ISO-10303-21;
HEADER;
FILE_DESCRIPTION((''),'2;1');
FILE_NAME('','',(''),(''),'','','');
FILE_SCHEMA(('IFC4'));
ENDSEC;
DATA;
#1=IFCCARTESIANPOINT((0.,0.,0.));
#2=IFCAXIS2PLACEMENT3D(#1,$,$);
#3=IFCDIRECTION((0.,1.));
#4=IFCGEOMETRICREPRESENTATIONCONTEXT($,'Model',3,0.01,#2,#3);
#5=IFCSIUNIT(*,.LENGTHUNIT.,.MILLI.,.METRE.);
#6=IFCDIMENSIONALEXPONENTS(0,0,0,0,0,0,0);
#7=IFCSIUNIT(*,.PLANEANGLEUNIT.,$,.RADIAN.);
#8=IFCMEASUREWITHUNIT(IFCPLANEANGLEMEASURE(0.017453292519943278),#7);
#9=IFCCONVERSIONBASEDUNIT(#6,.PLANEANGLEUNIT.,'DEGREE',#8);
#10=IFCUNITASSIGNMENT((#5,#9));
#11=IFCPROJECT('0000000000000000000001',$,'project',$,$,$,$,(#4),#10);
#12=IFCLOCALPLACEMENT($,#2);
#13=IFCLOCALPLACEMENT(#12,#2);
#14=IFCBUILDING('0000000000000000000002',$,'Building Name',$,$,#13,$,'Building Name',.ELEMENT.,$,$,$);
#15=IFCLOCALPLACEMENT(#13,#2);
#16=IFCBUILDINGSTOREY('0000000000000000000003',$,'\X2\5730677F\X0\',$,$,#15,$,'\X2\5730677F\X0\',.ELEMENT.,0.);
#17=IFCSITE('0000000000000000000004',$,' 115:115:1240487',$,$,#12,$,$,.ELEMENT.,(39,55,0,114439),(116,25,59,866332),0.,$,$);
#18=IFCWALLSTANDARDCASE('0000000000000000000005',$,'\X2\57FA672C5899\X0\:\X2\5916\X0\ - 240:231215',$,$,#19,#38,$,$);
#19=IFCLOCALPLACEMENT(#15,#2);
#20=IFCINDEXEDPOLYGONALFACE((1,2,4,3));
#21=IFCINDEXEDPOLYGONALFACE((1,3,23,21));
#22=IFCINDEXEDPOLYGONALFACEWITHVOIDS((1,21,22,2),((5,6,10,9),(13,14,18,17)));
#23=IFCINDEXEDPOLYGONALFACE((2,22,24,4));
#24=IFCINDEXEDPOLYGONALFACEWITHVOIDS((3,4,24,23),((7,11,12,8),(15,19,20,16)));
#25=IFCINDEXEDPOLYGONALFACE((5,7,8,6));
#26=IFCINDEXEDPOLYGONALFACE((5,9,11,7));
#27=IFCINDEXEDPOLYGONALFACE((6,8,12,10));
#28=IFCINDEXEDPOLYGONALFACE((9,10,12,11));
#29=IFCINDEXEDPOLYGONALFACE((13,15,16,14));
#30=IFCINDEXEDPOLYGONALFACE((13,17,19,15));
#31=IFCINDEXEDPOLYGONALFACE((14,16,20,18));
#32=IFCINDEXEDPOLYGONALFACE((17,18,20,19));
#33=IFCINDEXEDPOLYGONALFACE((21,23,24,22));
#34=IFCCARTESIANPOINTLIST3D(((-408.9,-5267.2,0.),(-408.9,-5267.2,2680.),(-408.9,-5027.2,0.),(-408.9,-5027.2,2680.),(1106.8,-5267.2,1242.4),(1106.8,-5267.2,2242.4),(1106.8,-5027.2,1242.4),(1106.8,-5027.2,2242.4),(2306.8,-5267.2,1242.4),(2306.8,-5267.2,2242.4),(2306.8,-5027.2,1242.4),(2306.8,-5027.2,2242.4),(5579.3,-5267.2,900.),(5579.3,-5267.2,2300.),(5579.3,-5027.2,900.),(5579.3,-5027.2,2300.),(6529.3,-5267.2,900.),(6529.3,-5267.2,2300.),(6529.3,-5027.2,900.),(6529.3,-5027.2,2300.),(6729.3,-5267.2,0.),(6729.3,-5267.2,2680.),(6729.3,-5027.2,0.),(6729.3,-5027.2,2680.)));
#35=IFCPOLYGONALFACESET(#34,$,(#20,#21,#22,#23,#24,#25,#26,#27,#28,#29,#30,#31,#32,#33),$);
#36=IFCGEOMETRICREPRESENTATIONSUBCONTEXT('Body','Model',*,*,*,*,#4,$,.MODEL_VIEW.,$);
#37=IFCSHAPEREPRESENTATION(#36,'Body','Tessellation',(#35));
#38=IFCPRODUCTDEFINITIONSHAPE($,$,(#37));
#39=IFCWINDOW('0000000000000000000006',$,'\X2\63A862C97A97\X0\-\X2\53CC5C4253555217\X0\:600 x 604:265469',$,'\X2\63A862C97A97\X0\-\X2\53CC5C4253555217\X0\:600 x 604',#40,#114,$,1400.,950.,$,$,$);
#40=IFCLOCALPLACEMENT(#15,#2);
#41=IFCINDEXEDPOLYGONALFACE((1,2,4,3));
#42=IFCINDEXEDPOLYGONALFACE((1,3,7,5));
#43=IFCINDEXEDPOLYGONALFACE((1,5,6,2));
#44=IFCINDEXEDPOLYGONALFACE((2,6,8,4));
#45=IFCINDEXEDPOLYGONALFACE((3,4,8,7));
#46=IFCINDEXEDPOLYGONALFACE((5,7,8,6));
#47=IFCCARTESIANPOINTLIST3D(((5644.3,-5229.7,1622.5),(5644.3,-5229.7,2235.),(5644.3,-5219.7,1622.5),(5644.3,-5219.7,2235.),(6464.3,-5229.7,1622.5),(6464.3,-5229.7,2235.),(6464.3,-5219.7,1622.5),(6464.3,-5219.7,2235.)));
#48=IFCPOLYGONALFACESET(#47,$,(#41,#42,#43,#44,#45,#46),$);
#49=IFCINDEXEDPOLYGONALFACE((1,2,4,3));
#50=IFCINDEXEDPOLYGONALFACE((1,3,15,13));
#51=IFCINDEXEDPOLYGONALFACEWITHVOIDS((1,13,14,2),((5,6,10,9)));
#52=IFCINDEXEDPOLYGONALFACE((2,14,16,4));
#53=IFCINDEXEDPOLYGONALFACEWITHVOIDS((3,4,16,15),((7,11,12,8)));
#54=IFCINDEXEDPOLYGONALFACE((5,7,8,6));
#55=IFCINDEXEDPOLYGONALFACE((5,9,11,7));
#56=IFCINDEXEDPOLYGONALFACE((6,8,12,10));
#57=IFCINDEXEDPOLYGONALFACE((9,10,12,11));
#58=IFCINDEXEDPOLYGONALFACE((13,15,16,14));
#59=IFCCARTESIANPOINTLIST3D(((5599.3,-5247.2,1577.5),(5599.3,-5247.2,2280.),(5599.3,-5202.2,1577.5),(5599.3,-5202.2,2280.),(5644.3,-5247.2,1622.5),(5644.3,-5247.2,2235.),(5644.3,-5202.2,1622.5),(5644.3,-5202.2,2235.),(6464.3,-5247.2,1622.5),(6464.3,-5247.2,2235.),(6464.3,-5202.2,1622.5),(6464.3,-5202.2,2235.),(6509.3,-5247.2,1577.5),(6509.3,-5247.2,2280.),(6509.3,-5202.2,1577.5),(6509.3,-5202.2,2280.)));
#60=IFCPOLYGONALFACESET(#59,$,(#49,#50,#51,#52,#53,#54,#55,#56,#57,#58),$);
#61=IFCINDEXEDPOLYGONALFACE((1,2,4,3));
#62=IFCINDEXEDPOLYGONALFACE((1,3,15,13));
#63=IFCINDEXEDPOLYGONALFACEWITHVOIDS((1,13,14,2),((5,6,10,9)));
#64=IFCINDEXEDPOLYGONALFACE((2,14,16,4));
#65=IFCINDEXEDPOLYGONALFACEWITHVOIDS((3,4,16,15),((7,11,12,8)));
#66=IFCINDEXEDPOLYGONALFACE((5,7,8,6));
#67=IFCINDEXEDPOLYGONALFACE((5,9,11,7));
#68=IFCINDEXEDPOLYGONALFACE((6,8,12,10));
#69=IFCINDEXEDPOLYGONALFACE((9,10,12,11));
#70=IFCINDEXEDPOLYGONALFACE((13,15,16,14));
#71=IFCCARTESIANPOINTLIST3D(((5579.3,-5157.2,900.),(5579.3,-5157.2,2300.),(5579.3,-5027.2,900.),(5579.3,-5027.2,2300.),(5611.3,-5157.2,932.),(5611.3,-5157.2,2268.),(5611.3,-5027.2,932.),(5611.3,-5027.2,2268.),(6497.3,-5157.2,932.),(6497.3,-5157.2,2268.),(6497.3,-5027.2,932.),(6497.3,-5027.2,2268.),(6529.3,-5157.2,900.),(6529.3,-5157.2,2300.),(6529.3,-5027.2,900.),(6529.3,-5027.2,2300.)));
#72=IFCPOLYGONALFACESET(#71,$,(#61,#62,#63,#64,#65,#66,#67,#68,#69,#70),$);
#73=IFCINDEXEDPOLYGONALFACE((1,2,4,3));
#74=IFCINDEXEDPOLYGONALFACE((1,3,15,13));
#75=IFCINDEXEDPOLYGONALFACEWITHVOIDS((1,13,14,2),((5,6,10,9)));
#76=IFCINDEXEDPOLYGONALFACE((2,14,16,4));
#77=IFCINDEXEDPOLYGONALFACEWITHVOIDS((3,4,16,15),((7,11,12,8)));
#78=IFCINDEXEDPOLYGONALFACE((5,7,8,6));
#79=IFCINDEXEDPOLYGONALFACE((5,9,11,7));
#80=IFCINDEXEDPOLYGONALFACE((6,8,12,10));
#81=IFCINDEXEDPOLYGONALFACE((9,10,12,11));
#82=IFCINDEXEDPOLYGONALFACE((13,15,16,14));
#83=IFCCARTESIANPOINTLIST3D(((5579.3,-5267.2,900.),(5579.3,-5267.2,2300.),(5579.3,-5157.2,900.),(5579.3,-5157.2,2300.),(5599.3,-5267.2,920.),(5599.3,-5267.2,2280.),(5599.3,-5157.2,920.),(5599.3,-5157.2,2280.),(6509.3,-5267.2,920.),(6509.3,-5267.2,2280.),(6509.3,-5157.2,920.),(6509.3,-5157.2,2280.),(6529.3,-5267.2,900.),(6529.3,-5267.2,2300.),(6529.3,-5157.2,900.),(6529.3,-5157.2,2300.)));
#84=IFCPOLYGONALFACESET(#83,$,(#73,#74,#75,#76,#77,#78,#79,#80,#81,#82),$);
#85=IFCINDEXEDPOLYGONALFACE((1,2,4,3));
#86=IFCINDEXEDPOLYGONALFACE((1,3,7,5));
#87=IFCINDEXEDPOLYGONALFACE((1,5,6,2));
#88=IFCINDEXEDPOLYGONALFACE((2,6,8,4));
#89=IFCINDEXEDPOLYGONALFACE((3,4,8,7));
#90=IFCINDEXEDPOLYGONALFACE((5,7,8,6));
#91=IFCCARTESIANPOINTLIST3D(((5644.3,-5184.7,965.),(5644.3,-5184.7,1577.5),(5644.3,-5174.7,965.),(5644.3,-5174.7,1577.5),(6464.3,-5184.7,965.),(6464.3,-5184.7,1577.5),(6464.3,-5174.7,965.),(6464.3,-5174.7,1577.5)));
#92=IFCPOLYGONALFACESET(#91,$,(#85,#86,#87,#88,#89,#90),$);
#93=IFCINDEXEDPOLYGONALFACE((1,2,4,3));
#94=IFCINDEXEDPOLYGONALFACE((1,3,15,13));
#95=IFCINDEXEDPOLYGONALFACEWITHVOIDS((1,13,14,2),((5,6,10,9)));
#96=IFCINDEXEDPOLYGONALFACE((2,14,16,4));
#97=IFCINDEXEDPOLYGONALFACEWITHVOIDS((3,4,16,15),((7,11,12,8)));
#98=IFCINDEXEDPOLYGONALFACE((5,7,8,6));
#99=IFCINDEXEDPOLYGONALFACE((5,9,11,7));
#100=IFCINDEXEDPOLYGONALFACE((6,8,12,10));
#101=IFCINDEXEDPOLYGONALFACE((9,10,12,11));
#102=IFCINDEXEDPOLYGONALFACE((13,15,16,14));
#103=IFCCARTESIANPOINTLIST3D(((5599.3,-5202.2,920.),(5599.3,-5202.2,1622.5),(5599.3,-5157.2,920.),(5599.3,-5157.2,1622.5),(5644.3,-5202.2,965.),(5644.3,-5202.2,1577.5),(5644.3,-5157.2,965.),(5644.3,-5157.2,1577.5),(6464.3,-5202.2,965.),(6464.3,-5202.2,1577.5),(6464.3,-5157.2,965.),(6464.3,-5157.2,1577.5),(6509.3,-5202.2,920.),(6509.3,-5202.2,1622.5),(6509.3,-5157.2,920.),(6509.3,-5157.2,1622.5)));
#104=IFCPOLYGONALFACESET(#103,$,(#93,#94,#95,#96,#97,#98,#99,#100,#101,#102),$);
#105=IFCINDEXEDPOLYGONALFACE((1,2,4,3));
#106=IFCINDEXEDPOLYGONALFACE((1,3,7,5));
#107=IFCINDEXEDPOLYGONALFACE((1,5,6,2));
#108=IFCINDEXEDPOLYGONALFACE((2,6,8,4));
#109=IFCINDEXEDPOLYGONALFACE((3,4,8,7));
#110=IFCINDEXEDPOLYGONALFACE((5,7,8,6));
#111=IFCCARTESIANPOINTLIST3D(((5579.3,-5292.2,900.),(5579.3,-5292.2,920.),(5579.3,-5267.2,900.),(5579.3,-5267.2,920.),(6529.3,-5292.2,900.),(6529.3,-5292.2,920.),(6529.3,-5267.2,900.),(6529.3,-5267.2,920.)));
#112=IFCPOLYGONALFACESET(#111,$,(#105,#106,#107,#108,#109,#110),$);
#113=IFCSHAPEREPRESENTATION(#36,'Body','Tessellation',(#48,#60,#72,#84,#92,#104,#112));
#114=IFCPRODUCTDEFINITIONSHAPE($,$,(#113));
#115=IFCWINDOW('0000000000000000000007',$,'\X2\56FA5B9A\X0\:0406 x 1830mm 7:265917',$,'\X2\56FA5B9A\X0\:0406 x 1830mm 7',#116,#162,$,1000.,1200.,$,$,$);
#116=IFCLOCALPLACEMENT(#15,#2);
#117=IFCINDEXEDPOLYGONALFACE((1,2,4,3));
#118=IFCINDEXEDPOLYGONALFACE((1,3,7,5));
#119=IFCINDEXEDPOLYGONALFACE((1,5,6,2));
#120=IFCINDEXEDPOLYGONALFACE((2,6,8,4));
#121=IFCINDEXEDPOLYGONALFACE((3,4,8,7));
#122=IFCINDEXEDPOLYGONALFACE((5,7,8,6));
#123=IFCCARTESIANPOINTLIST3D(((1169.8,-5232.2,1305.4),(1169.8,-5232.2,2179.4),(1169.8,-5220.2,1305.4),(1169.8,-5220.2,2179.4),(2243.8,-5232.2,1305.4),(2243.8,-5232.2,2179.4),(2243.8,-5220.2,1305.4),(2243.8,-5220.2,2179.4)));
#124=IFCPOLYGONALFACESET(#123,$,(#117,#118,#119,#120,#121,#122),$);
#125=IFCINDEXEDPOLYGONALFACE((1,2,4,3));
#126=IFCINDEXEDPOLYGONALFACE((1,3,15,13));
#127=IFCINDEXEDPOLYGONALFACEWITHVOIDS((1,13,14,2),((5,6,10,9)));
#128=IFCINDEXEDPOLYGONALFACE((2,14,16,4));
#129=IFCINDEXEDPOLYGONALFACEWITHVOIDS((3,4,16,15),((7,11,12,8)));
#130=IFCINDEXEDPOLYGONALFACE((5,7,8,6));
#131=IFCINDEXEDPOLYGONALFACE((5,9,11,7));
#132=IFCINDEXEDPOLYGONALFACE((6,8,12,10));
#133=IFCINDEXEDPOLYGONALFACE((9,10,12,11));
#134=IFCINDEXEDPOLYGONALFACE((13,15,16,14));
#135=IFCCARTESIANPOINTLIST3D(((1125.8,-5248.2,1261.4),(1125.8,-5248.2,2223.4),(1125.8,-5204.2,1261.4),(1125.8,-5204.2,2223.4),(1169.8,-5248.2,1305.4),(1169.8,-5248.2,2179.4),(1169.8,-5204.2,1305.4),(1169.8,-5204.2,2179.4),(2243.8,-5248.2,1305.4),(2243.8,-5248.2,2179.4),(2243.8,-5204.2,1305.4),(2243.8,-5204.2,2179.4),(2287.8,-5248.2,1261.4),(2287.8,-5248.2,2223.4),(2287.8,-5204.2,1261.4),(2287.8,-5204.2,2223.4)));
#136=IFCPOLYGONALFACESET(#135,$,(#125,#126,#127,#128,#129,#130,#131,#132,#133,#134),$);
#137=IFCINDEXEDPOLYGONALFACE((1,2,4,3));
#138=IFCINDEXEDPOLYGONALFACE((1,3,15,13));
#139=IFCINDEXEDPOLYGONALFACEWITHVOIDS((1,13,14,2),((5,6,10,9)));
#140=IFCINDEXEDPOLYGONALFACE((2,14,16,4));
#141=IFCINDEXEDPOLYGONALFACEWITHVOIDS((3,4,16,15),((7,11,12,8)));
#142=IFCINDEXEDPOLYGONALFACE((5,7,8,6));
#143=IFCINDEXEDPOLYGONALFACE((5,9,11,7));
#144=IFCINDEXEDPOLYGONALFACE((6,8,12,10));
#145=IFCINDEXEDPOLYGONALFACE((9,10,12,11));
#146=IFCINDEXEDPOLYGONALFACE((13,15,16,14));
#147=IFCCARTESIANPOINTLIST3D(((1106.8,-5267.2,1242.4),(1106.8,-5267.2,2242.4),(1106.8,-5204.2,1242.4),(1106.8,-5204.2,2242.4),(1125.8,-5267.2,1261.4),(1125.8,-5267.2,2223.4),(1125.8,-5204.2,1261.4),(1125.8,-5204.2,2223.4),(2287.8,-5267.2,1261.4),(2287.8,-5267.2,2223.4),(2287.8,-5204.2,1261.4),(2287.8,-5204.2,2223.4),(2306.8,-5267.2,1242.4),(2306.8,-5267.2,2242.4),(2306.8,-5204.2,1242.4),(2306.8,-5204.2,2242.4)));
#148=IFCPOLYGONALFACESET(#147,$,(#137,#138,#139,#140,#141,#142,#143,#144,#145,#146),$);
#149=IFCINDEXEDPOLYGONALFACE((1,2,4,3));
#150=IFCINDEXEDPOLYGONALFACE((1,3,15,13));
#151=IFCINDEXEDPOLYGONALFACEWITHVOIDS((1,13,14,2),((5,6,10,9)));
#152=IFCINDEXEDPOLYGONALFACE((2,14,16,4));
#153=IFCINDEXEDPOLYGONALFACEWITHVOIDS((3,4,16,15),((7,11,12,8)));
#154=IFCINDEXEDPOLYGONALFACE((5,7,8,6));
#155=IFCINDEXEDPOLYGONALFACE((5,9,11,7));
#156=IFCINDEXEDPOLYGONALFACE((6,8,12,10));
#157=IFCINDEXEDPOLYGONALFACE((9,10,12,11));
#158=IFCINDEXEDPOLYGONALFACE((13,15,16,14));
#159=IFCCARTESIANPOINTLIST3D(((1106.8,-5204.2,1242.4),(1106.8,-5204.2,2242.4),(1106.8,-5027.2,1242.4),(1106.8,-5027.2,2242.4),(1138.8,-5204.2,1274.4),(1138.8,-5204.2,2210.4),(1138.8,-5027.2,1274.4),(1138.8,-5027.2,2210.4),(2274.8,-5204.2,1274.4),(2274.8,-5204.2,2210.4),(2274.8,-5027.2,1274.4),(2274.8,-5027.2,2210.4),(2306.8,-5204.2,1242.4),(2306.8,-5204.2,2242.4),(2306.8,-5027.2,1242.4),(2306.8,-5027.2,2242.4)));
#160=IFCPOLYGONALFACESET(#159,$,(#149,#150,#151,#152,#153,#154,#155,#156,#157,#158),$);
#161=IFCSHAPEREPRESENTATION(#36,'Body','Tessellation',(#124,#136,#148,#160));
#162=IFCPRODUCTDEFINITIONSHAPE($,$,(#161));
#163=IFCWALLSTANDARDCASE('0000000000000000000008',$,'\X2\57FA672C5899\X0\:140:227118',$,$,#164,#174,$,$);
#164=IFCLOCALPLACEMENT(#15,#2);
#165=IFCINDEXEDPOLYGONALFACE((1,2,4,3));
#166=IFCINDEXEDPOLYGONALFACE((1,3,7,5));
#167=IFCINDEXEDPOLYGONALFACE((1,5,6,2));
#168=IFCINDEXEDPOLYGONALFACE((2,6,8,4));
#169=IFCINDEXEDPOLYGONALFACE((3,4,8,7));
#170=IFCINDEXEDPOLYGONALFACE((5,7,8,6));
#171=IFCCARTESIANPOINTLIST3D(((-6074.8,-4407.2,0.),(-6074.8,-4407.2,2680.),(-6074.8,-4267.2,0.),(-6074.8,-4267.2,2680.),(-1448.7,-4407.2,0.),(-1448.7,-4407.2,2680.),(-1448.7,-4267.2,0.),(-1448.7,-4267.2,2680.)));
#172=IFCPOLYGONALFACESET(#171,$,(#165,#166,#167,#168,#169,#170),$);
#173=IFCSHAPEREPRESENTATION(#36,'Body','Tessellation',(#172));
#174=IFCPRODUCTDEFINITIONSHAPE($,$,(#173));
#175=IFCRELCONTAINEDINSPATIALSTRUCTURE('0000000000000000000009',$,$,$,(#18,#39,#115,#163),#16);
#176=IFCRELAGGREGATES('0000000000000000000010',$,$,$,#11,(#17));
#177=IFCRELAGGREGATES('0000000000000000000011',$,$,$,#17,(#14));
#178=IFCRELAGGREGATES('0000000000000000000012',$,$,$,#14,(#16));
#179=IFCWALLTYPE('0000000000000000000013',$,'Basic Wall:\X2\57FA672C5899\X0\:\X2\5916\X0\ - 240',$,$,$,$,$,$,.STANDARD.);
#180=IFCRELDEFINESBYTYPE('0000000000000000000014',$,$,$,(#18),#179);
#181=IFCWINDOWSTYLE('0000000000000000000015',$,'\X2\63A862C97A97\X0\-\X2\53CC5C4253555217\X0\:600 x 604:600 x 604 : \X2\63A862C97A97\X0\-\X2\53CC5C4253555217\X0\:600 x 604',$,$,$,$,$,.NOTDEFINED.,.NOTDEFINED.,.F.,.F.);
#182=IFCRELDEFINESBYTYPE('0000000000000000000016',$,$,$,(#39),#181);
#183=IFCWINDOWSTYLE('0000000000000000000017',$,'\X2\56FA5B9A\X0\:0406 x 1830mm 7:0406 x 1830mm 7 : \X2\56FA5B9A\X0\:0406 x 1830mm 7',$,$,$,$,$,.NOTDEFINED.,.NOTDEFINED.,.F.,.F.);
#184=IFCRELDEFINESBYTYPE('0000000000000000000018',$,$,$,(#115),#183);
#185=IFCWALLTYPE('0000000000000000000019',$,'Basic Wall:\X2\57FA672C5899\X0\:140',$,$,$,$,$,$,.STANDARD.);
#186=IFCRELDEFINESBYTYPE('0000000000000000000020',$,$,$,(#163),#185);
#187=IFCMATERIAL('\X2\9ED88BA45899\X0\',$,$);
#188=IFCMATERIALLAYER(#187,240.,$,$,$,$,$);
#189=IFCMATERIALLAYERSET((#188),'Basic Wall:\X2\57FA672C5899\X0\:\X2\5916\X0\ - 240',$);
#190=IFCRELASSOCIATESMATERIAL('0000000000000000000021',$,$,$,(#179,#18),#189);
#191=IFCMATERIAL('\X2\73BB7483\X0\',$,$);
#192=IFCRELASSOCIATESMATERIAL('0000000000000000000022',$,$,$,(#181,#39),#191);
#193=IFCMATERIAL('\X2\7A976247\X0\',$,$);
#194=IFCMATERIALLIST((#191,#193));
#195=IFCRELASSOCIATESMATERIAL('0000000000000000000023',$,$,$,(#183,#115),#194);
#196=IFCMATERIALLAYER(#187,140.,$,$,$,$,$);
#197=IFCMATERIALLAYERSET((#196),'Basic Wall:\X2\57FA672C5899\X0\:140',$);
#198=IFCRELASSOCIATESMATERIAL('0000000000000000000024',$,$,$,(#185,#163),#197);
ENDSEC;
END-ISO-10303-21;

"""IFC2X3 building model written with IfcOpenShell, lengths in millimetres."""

from ifc_helpers import new_model, entity, si_unit, converted_unit, direction, frame, frame_2d, origin, origin_2d_with_axis, place, context, subcontext, project, spatial, polyline, rectangle, outline, extrude, source, transform, mapped, material, material_list, layer, layer_set, layer_usage, type_object, type_shapes, element, fill, save


model = new_model("IFC2X3")

# Units and contexts
model_context = context("Model", 3, precision=0.01, world=origin(), true_north=direction((0.0, 1.0)))
body_context = subcontext(model_context, "Body", "Model", "MODEL_VIEW")
ifc_project = project(units=[si_unit("LENGTHUNIT", "METRE", prefix="MILLI"), converted_unit("PLANEANGLEUNIT", "DEGREE", entity("IfcPlaneAngleMeasure", 0.017453292519943278), si_unit("PLANEANGLEUNIT", "RADIAN"), dimensions=[0, 0, 0, 0, 0, 0, 0])], contexts=[model_context])

# Site, building, storey
site_placement = place(None, origin())
site = spatial("IfcSite", under=ifc_project, at=site_placement, Name=" 115:115:1240487", CompositionType="ELEMENT", RefLatitude=(39, 55, 0, 114439), RefLongitude=(116, 25, 59, 866332), RefElevation=0.0)
building_placement = place(site_placement, origin())
building = spatial("IfcBuilding", under=site, at=building_placement, Name="Building Name", LongName="Building Name", CompositionType="ELEMENT")
storey_placement = place(building_placement, origin())
storey = spatial("IfcBuildingStorey", under=building, at=storey_placement, Name="地板", LongName="地板", CompositionType="ELEMENT", Elevation=0.0)

# Shared definitions
ifc_material_1 = material(Name="默认墙")

# Shared definitions
ifc_layer_1 = layer(ifc_material_1, 240.0)
ifc_layer_set_1 = layer_set([ifc_layer_1], Name="Basic Wall:基本墙:外 - 240")
wall_type_1 = type_object("IfcWallType", Name="Basic Wall:基本墙:外 - 240", PredefinedType="STANDARD", material=ifc_layer_set_1)

# Wall, openings, windows
ifc_material_2 = material(Name="玻璃")
window_style_1 = type_object("IfcWindowStyle", Name="推拉窗-双层单列:600 x 604:600 x 604 : 推拉窗-双层单列:600 x 604", ConstructionType="NOTDEFINED", OperationType="NOTDEFINED", ParameterTakesPrecedence=False, Sizeable=False, material=ifc_material_2)
shared_shape_1 = source(origin(), body_context, "Body", "SweptSolid", [
    extrude(rectangle(XDim=820.0, YDim=10.0, at=origin_2d_with_axis()), frame((475.0, -44.9, 722.5)), (0.0, 0.0, 1.0), 612.5),
    extrude(outline(polyline([(-351.2, -455.0), (351.2, -455.0), (351.2, 455.0), (-351.2, 455.0), (-351.2, -455.0)]), holes=[polyline([(306.2, 410.0), (306.2, -410.0), (-306.2, -410.0), (-306.2, 410.0), (306.2, 410.0)])]), frame((475.0, -67.4, 1028.7), z_axis=(0.0, 1.0, 0.0), x_axis=(0.0, 0.0, -1.0)), (0.0, 0.0, 1.0), 45.0),
    extrude(outline(polyline([(-700.0, -475.0), (700.0, -475.0), (700.0, 475.0), (-700.0, 475.0), (-700.0, -475.0)]), holes=[polyline([(668.0, 443.0), (668.0, -443.0), (-668.0, -443.0), (-668.0, 443.0), (668.0, 443.0)])]), frame((475.0, -242.4, 700.0), z_axis=(0.0, 1.0, 0.0), x_axis=(0.0, 0.0, -1.0)), (0.0, 0.0, 1.0), 130.0),
    extrude(outline(polyline([(-475.0, -700.0), (475.0, -700.0), (475.0, 700.0), (-475.0, 700.0), (-475.0, -700.0)]), holes=[polyline([(455.0, 680.0), (455.0, -680.0), (-455.0, -680.0), (-455.0, 680.0), (455.0, 680.0)])]), frame((475.0, -112.4, 700.0), z_axis=(0.0, 1.0, 0.0), x_axis=(-1.0, 0.0, 0.0)), (0.0, 0.0, 1.0), 110.0),
    extrude(rectangle(XDim=820.0, YDim=10.0, at=origin_2d_with_axis()), frame((475.0, -89.9, 65.0)), (0.0, 0.0, 1.0), 612.5),
    extrude(outline(polyline([(-351.2, -455.0), (351.2, -455.0), (351.2, 455.0), (-351.2, 455.0), (-351.2, -455.0)]), holes=[polyline([(306.2, 410.0), (306.3, -410.0), (-306.2, -410.0), (-306.2, 410.0), (306.2, 410.0)])]), frame((475.0, -112.4, 371.3), z_axis=(0.0, 1.0, 0.0), x_axis=(0.0, 0.0, -1.0)), (0.0, 0.0, 1.0), 45.0),
    extrude(rectangle(XDim=950.0, YDim=25.0, at=origin_2d_with_axis()), frame((475.0, 10.1, 0.0)), (0.0, 0.0, 1.0), 20.0),
])
type_shapes(window_style_1, [shared_shape_1])
ifc_layer_usage_1 = layer_usage(ifc_layer_set_1, "AXIS2", "NEGATIVE", 120.0)
wall_1_placement = place(storey_placement, frame((-408.9, -5147.2, 0.0)))
wall_1 = element("IfcWallStandardCase", 1, at=wall_1_placement, inside=storey, type_object=wall_type_1, material=ifc_layer_usage_1, Name="基本墙:外 - 240:231215", context=body_context, shape_type="SweptSolid", body=[
    extrude(rectangle(XDim=7138.2, YDim=240.0, at=frame_2d((3569.1, 0.0), x_axis=(-1.0, 0.0))), origin(), (0.0, 0.0, 1.0), 2680.0),
])
opening_1_placement = place(wall_1_placement, frame((408.9, 5147.2, 0.0)))
opening_1 = element("IfcOpeningElement", 2, at=opening_1_placement, cuts=wall_1, ObjectType="Opening", context=body_context, shape_type="SweptSolid", body=[
    extrude(rectangle(XDim=1400.0, YDim=950.0, at=frame_2d((0.0, 0.0), x_axis=(1.0, 0.0))), frame((6054.3, -5269.6, 1600.0), z_axis=(0.0, 1.0, 0.0), x_axis=(0.0, 0.0, 1.0)), (0.0, 0.0, 1.0), 244.8),
])
opening_2_placement = place(wall_1_placement, frame((408.9, 5147.2, 0.0)))
opening_2 = element("IfcOpeningElement", 3, at=opening_2_placement, cuts=wall_1, ObjectType="Opening", context=body_context, shape_type="SweptSolid", body=[
    extrude(rectangle(XDim=1000.0, YDim=1200.0, at=origin_2d_with_axis()), frame((1706.8, -5269.6, 1742.4), z_axis=(0.0, 1.0, 0.0), x_axis=(0.0, 0.0, -1.0)), (0.0, 0.0, 1.0), 244.8),
])
window_1_placement = place(opening_1_placement, frame((6529.3, -5269.6, 900.0), z_axis=(0.0, 0.0, 1.0), x_axis=(-1.0, 0.0, 0.0)))
window_1 = element("IfcWindow", 4, at=window_1_placement, inside=storey, type_object=window_style_1, material=ifc_material_2, Name="推拉窗-双层单列:600 x 604:265469", ObjectType="推拉窗-双层单列:600 x 604", OverallHeight=1400.0, OverallWidth=950.0, context=body_context, shape_type="MappedRepresentation", body=[
    mapped(shared_shape_1, transform((0.0, 0.0, 0.0), scale=1.0)),
])
fill(opening_1, window_1)
ifc_material_3 = material(Name="窗扇")
ifc_material_list = material_list([ifc_material_2, ifc_material_3])
window_style_2 = type_object("IfcWindowStyle", Name="固定:0406 x 1830mm 7:0406 x 1830mm 7 : 固定:0406 x 1830mm 7", ConstructionType="NOTDEFINED", OperationType="NOTDEFINED", ParameterTakesPrecedence=False, Sizeable=False, material=ifc_material_list)
shared_shape_2 = source(origin(), body_context, "Body", "SweptSolid", [
    extrude(rectangle(XDim=1074.0, YDim=12.0, at=origin_2d_with_axis()), frame((600.0, 201.4, 63.0)), (0.0, 0.0, 1.0), 874.0),
    extrude(outline(polyline([(-481.0, -581.0), (481.0, -581.0), (481.0, 581.0), (-481.0, 581.0), (-481.0, -581.0)]), holes=[polyline([(437.0, 537.0), (437.0, -537.0), (-437.0, -537.0), (-437.0, 537.0), (437.0, 537.0)])]), frame((600.0, 179.4, 500.0), z_axis=(0.0, 1.0, 0.0), x_axis=(0.0, 0.0, -1.0)), (0.0, 0.0, 1.0), 44.0),
    extrude(outline(polyline([(-500.0, -600.0), (500.0, -600.0), (500.0, 600.0), (-500.0, 600.0), (-500.0, -600.0)]), holes=[polyline([(481.0, 581.0), (481.0, -581.0), (-481.0, -581.0), (-481.0, 581.0), (481.0, 581.0)])]), frame((600.0, 179.4, 500.0), z_axis=(0.0, 1.0, 0.0), x_axis=(0.0, 0.0, -1.0)), (0.0, 0.0, 1.0), 63.0),
    extrude(outline(polyline([(-500.0, -600.0), (500.0, -600.0), (500.0, 600.0), (-500.0, 600.0), (-500.0, -600.0)]), holes=[polyline([(468.0, 568.0), (468.0, -568.0), (-468.0, -568.0), (-468.0, 568.0), (468.0, 568.0)])]), frame((600.0, 2.4, 500.0), z_axis=(0.0, 1.0, 0.0), x_axis=(0.0, 0.0, -1.0)), (0.0, 0.0, 1.0), 177.0),
])
type_shapes(window_style_2, [shared_shape_2])
window_2_placement = place(opening_2_placement, frame((2306.8, -5024.8, 1242.4), z_axis=(0.0, 0.0, 1.0), x_axis=(-1.0, 0.0, 0.0)))
window_2 = element("IfcWindow", 5, at=window_2_placement, inside=storey, type_object=window_style_2, material=ifc_material_list, Name="固定:0406 x 1830mm 7:265917", ObjectType="固定:0406 x 1830mm 7", OverallHeight=1000.0, OverallWidth=1200.0, context=body_context, shape_type="MappedRepresentation", body=[
    mapped(shared_shape_2, transform((0.0, 0.0, 0.0), scale=1.0)),
])
fill(opening_2, window_2)

# Wall
ifc_layer_2 = layer(ifc_material_1, 140.0)
ifc_layer_set_2 = layer_set([ifc_layer_2], Name="Basic Wall:基本墙:140")
ifc_layer_usage_2 = layer_usage(ifc_layer_set_2, "AXIS2", "NEGATIVE", 70.0)
wall_type_2 = type_object("IfcWallType", Name="Basic Wall:基本墙:140", PredefinedType="STANDARD", material=ifc_layer_set_2)
wall_2_placement = place(storey_placement, frame((-1448.7, -4337.2, 0.0), z_axis=(0.0, 0.0, 1.0), x_axis=(-1.0, 0.0, 0.0)))
element("IfcWallStandardCase", 6, at=wall_2_placement, inside=storey, type_object=wall_type_2, material=ifc_layer_usage_2, Name="基本墙:140:227118", context=body_context, shape_type="SweptSolid", body=[
    extrude(rectangle(XDim=4626.1, YDim=140.0, at=frame_2d((2313.1, 0.0), x_axis=(-1.0, 0.0))), origin(), (0.0, 0.0, 1.0), 2680.0),
])

save(model, "model.ifc")
